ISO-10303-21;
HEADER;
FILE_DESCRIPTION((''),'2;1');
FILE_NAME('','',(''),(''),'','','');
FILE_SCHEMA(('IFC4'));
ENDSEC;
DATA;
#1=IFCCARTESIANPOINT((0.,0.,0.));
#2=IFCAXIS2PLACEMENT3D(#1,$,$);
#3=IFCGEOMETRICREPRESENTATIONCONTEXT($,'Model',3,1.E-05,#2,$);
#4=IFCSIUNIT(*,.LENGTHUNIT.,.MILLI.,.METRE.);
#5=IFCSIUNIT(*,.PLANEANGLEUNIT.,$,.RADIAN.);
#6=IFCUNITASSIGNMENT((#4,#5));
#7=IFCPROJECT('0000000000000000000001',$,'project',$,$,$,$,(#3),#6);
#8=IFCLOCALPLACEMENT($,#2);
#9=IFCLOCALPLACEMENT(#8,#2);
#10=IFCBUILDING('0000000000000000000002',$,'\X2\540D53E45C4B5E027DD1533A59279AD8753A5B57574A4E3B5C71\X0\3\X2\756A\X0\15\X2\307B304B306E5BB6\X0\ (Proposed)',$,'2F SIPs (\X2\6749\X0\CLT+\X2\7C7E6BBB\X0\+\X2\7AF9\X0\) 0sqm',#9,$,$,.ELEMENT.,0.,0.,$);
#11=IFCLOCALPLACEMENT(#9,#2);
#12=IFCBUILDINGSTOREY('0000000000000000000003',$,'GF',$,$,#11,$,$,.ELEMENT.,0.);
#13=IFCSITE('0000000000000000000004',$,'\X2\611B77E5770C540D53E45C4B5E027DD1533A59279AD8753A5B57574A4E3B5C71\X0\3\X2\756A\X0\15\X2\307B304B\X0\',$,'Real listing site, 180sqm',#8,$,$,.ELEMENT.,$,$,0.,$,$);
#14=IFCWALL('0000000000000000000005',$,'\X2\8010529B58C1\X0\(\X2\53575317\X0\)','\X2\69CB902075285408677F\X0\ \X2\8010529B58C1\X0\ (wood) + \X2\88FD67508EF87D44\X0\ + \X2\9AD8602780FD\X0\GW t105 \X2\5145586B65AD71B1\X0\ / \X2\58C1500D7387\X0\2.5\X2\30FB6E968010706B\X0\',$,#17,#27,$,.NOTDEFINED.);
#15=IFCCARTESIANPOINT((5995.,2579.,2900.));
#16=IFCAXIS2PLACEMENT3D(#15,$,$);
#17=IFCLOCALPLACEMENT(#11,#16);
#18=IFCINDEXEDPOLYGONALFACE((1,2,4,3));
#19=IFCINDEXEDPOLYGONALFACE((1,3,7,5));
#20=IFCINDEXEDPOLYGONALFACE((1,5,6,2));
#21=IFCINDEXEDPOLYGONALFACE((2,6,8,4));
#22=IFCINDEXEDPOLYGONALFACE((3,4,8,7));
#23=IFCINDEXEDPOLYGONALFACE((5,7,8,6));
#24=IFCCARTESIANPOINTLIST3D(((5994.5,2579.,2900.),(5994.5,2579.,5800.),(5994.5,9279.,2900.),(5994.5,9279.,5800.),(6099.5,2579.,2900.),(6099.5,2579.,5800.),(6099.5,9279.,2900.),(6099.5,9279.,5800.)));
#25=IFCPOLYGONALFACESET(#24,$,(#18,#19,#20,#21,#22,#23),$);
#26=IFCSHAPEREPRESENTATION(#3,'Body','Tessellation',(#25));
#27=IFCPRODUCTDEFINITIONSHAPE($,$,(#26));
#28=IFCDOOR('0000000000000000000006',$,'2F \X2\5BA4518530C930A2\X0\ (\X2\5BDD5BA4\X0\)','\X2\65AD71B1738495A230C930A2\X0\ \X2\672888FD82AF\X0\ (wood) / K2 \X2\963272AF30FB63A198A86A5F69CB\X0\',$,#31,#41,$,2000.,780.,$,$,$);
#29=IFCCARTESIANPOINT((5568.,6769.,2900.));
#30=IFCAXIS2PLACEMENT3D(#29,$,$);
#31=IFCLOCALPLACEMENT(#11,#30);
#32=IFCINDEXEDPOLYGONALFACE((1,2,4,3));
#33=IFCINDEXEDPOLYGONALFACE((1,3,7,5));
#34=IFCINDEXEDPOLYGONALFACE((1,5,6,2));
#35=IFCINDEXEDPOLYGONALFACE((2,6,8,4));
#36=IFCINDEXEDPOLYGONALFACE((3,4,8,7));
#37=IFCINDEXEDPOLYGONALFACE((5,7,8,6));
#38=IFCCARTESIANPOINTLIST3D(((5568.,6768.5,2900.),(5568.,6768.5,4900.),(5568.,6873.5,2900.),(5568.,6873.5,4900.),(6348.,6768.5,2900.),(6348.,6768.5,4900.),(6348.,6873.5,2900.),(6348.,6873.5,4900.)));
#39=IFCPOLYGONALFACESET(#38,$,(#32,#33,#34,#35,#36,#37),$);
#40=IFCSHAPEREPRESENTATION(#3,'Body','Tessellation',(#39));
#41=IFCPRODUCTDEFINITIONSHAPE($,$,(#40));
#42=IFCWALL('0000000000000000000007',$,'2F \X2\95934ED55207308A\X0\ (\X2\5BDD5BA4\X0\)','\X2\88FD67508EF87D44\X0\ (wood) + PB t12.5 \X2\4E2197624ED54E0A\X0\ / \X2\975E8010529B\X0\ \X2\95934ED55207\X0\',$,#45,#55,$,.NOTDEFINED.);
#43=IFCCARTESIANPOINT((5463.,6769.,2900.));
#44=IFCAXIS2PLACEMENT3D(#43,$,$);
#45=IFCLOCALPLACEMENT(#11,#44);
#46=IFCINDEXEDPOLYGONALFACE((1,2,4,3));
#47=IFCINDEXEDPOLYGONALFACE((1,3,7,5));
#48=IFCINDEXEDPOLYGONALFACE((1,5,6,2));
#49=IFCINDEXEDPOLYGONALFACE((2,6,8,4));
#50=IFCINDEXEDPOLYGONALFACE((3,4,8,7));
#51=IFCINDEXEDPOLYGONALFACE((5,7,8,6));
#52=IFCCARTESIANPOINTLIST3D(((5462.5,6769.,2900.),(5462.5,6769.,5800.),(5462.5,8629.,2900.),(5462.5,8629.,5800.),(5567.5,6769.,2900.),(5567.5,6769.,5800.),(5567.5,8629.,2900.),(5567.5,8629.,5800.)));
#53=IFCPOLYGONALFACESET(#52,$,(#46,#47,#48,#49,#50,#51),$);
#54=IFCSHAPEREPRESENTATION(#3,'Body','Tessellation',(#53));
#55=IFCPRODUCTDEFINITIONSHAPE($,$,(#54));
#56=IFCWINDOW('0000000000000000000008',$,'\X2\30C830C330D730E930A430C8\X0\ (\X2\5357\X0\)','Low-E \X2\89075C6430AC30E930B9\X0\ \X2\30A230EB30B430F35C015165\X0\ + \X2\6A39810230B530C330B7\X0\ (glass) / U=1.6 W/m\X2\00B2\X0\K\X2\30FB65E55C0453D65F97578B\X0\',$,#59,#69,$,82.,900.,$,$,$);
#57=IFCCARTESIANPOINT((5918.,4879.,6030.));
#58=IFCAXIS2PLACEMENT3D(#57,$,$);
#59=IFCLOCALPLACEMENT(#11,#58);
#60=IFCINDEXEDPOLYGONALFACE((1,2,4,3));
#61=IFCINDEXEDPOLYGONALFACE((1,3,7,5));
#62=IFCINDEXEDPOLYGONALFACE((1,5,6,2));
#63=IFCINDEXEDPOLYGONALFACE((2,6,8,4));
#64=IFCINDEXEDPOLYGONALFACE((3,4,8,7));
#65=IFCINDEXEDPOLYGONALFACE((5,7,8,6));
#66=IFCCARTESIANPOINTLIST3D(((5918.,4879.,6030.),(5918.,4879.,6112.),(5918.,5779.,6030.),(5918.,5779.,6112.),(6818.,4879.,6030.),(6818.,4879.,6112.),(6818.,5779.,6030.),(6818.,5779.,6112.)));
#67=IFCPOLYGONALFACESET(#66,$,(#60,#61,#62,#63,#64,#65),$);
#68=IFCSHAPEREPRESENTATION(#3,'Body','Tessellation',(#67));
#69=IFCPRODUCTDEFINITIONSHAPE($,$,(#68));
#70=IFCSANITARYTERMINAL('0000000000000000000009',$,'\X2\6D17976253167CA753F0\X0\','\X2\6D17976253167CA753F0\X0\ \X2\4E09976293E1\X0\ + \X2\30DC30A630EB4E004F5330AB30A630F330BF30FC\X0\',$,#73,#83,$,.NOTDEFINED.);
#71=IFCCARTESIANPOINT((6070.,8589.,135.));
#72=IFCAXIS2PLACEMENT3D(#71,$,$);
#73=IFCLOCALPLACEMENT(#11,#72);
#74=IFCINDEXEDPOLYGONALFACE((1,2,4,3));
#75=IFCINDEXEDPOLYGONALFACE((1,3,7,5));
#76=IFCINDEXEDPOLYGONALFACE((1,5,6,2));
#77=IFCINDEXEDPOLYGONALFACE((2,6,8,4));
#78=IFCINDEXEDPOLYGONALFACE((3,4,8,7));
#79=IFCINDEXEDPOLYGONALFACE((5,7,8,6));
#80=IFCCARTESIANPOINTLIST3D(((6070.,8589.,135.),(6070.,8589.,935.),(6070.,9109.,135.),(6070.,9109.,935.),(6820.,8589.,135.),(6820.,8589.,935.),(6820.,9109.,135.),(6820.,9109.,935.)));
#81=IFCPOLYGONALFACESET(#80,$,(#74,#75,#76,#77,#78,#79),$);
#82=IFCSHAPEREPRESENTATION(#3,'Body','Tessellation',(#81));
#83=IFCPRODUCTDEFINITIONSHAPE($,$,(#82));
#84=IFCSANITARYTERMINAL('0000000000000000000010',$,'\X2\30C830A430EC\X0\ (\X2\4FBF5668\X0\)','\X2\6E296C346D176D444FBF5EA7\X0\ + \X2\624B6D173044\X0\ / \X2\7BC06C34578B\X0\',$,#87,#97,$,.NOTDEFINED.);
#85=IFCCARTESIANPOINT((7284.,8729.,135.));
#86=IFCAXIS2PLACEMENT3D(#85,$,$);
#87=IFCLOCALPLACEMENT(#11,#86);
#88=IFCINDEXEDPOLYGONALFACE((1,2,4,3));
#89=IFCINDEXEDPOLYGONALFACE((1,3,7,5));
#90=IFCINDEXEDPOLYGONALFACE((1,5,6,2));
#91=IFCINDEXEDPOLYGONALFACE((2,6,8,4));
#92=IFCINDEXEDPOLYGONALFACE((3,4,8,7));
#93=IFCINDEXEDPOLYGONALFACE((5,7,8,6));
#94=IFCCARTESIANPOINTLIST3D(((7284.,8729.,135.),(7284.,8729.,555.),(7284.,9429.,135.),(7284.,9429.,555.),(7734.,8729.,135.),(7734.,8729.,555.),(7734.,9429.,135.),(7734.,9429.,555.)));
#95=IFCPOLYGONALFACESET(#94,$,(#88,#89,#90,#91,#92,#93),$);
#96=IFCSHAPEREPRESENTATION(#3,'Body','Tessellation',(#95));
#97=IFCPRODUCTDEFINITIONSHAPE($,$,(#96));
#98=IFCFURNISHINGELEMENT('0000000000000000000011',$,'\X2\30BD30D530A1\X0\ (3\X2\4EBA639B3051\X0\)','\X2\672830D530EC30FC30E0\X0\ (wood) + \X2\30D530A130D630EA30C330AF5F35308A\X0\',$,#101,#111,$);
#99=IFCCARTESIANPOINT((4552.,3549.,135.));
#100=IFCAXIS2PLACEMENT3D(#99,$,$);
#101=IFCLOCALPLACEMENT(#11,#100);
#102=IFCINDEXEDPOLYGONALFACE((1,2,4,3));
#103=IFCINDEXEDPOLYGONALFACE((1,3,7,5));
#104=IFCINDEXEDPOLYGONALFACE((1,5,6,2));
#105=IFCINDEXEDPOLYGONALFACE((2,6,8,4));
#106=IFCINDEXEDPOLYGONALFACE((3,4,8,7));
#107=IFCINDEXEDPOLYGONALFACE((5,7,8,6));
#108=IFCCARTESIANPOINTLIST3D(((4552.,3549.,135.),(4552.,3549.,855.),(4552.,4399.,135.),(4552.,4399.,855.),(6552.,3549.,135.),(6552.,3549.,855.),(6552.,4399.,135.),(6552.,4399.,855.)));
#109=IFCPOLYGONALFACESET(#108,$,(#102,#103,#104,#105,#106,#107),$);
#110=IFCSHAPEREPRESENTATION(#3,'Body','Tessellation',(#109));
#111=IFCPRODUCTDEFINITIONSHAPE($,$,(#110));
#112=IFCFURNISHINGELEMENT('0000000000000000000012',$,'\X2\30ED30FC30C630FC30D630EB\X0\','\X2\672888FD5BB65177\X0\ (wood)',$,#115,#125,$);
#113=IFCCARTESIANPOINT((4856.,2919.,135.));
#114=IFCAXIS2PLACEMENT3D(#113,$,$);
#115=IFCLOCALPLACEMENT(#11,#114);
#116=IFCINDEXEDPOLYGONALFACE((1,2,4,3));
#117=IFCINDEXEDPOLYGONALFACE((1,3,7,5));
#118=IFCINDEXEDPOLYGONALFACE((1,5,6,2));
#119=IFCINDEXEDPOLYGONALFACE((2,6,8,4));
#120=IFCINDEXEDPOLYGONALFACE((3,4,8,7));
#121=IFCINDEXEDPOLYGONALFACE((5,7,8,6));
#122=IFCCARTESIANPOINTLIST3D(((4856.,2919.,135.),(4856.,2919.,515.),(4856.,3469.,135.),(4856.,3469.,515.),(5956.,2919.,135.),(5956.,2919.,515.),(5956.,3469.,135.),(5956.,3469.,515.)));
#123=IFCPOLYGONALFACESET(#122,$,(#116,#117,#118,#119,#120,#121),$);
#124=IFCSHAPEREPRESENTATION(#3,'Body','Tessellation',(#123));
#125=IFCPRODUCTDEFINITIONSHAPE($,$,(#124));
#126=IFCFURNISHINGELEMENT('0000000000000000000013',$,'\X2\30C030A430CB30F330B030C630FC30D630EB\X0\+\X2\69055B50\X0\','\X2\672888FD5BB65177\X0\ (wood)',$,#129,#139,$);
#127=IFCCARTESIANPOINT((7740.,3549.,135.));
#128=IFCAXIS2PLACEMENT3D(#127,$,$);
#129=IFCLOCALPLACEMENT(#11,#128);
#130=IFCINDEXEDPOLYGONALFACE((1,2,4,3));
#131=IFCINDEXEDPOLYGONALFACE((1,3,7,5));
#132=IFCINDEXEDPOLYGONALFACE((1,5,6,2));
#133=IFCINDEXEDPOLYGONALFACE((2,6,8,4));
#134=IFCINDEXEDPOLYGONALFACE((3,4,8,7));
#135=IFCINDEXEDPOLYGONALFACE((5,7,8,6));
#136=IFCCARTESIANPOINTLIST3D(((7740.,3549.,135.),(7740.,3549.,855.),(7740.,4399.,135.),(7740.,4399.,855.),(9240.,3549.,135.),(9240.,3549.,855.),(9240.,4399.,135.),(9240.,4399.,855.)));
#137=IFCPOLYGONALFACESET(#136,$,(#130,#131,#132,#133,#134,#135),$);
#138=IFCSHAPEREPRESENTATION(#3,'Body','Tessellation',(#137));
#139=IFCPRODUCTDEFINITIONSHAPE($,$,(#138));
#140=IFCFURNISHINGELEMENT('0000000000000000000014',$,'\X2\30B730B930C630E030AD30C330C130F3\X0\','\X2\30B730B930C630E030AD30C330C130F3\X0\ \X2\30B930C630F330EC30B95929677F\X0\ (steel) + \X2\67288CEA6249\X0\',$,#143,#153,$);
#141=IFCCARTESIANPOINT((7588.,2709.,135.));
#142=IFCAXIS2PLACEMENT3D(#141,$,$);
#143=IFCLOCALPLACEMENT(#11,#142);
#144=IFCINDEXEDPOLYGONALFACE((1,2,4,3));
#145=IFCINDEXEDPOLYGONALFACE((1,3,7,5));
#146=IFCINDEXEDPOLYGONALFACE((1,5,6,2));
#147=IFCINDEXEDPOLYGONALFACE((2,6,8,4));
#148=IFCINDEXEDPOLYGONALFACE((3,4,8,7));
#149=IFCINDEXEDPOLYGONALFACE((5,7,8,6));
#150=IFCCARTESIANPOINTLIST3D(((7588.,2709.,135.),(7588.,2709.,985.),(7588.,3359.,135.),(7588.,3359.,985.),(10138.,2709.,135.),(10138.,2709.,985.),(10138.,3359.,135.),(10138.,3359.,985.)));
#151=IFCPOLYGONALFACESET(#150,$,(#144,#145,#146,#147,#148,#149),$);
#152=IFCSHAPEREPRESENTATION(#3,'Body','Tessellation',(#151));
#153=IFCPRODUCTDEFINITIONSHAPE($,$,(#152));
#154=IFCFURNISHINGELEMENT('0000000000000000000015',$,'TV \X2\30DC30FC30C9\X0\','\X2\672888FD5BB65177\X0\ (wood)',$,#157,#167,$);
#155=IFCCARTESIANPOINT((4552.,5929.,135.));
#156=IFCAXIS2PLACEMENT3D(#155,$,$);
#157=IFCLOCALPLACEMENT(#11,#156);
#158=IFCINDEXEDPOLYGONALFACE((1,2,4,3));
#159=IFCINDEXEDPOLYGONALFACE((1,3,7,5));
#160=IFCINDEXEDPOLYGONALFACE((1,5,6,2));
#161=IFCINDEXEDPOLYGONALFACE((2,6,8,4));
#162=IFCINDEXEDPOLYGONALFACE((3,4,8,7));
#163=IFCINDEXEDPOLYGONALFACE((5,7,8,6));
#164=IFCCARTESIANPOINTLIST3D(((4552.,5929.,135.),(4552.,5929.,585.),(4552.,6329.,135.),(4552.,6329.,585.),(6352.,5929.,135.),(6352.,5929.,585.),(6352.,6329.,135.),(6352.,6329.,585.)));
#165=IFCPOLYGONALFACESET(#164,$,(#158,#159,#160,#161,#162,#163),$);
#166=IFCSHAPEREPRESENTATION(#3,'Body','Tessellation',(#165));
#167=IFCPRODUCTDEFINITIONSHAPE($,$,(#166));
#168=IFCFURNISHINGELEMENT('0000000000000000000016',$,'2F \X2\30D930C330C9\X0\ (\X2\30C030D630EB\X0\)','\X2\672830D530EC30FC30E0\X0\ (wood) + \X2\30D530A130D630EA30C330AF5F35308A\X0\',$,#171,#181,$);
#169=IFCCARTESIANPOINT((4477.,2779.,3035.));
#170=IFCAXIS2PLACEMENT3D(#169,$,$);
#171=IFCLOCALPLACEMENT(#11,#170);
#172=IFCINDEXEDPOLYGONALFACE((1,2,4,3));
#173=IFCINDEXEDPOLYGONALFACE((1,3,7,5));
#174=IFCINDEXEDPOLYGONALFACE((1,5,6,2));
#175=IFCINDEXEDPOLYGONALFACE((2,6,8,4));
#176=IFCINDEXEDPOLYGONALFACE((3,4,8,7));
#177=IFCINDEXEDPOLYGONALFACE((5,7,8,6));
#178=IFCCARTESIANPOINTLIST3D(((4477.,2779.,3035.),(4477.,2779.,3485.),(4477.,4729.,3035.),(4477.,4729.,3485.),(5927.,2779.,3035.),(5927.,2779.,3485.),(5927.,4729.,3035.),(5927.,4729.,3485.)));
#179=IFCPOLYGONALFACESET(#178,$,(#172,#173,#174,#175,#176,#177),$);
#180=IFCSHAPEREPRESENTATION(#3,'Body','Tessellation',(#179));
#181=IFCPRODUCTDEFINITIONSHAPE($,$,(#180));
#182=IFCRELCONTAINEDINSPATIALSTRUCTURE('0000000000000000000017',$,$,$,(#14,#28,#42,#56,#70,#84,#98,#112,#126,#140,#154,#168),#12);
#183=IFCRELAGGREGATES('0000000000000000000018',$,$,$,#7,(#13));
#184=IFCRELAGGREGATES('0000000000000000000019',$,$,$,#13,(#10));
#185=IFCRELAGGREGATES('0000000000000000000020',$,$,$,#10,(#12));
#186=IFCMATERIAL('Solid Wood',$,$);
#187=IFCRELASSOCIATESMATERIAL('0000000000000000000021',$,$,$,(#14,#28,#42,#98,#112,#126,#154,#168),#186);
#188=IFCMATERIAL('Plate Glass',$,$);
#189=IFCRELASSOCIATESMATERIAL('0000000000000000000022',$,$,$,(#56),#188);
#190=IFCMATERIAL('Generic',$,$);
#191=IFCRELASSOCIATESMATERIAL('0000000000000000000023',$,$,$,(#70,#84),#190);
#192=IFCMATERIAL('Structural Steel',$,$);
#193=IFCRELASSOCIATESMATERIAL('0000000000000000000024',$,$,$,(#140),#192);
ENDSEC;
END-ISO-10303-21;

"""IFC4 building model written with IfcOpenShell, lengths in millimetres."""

from ifc_helpers import new_model, si_unit, frame, frame_2d, origin, place, context, project, spatial, rectangle, extrude, material, element, fill, save


model = new_model("IFC4")

# Units and contexts
model_context = context("Model", 3, precision=1e-05, world=origin())
ifc_project = project(units=[si_unit("LENGTHUNIT", "METRE", prefix="MILLI"), si_unit("PLANEANGLEUNIT", "RADIAN")], contexts=[model_context])

# Site, building, storey
site_placement = place(None, origin())
site = spatial("IfcSite", under=ifc_project, at=site_placement, Name="愛知県名古屋市緑区大高町字坊主山3番15ほか", ObjectType="Real listing site, 180sqm", CompositionType="ELEMENT", RefElevation=0.0)
building_placement = place(site_placement, origin())
building = spatial("IfcBuilding", under=site, at=building_placement, Name="名古屋市緑区大高町字坊主山3番15ほかの家 (Proposed)", ObjectType="2F SIPs (杉CLT+籾殻+竹) 0sqm", CompositionType="ELEMENT", ElevationOfRefHeight=0.0, ElevationOfTerrain=0.0)
storey_placement = place(building_placement, origin())
storey = spatial("IfcBuildingStorey", under=building, at=storey_placement, Name="GF", CompositionType="ELEMENT", Elevation=0.0)

# Shared definitions
ifc_material_1 = material(Name="Solid Wood")

# Wall, opening, door
wall_1_placement = place(storey_placement, frame((5995.0, 2579.0, 2900.0)))
wall_1 = element("IfcWall", 1, at=wall_1_placement, inside=storey, material=ifc_material_1, Name="耐力壁(南北)", Description="構造用合板 耐力壁 (wood) + 製材軸組 + 高性能GW t105 充填断熱 / 壁倍率2.5・準耐火", PredefinedType="NOTDEFINED", context=model_context, shape_type="SweptSolid", body=[
    extrude(rectangle(XDim=105.0, YDim=6700.0, at=frame_2d((52.0, 3350.0))), frame((5995.0, 2579.0, 2900.0)), (0.0, 0.0, 1.0), 2900.0),
])
opening_1_placement = place(storey_placement, frame((5568.0, 6769.0, 2900.0)))
opening_1 = element("IfcOpeningElement", 2, at=opening_1_placement, cuts=wall_1, PredefinedType="NOTDEFINED", context=model_context, shape_type="SweptSolid", body=[
    extrude(rectangle(XDim=780.0, YDim=105.0, at=frame_2d((390.0, 52.0))), frame((5568.0, 6769.0, 2900.0)), (0.0, 0.0, 1.0), 2000.0),
])
door_1_placement = place(storey_placement, frame((5568.0, 6769.0, 2900.0)))
door_1 = element("IfcDoor", 3, at=door_1_placement, inside=storey, material=ifc_material_1, Name="2F 室内ドア (寝室)", Description="断熱玄関ドア 木製芯 (wood) / K2 防犯・採風機構", OverallHeight=2000.0, OverallWidth=780.0, context=model_context, shape_type="SweptSolid", body=[
    extrude(rectangle(XDim=780.0, YDim=105.0, at=frame_2d((390.0, 52.0))), frame((5568.0, 6769.0, 2900.0)), (0.0, 0.0, 1.0), 2000.0),
])
fill(opening_1, door_1)

# Wall
wall_2_placement = place(storey_placement, frame((5463.0, 6769.0, 2900.0)))
element("IfcWall", 4, at=wall_2_placement, inside=storey, material=ifc_material_1, Name="2F 間仕切り (寝室)", Description="製材軸組 (wood) + PB t12.5 両面仕上 / 非耐力 間仕切", PredefinedType="NOTDEFINED", context=model_context, shape_type="SweptSolid", body=[
    extrude(rectangle(XDim=105.0, YDim=1860.0, at=frame_2d((52.0, 930.0))), frame((5463.0, 6769.0, 2900.0)), (0.0, 0.0, 1.0), 2900.0),
])

# Window
ifc_material_2 = material(Name="Plate Glass")
window_placement = place(storey_placement, frame((5918.0, 4879.0, 6030.0)))
element("IfcWindow", 5, at=window_placement, inside=storey, material=ifc_material_2, Name="トップライト (南)", Description="Low-E 複層ガラス アルゴン封入 + 樹脂サッシ (glass) / U=1.6 W/m²K・日射取得型", OverallHeight=82.0, OverallWidth=900.0, context=model_context, shape_type="SweptSolid", body=[
    extrude(rectangle(XDim=900.0, YDim=900.0, at=frame_2d((450.0, 450.0))), frame((5918.0, 4879.0, 6030.0)), (0.0, 0.0, 1.0), 82.0),
])

# Sanitary terminals
ifc_material_3 = material(Name="Generic")
sanitary_terminal_1_placement = place(storey_placement, frame((6070.0, 8589.0, 135.0)))
element("IfcSanitaryTerminal", 6, at=sanitary_terminal_1_placement, inside=storey, material=ifc_material_3, Name="洗面化粧台", Description="洗面化粧台 三面鏡 + ボウル一体カウンター", PredefinedType="NOTDEFINED", context=model_context, shape_type="SweptSolid", body=[
    extrude(rectangle(XDim=750.0, YDim=520.0, at=frame_2d((375.0, 260.0))), frame((6070.0, 8589.0, 135.0)), (0.0, 0.0, 1.0), 800.0),
])
sanitary_terminal_2_placement = place(storey_placement, frame((7284.0, 8729.0, 135.0)))
element("IfcSanitaryTerminal", 7, at=sanitary_terminal_2_placement, inside=storey, material=ifc_material_3, Name="トイレ (便器)", Description="温水洗浄便座 + 手洗い / 節水型", PredefinedType="NOTDEFINED", context=model_context, shape_type="SweptSolid", body=[
    extrude(rectangle(XDim=450.0, YDim=700.0, at=frame_2d((225.0, 350.0))), frame((7284.0, 8729.0, 135.0)), (0.0, 0.0, 1.0), 420.0),
])

# Furnishing elements
furnishing_1_placement = place(storey_placement, frame((4552.0, 3549.0, 135.0)))
element("IfcFurnishingElement", 8, at=furnishing_1_placement, inside=storey, material=ifc_material_1, Name="ソファ (3人掛け)", Description="木フレーム (wood) + ファブリック張り", context=model_context, shape_type="SweptSolid", body=[
    extrude(rectangle(XDim=2000.0, YDim=850.0, at=frame_2d((1000.0, 425.0))), frame((4552.0, 3549.0, 135.0)), (0.0, 0.0, 1.0), 720.0),
])
furnishing_2_placement = place(storey_placement, frame((4856.0, 2919.0, 135.0)))
element("IfcFurnishingElement", 9, at=furnishing_2_placement, inside=storey, material=ifc_material_1, Name="ローテーブル", Description="木製家具 (wood)", context=model_context, shape_type="SweptSolid", body=[
    extrude(rectangle(XDim=1100.0, YDim=550.0, at=frame_2d((550.0, 275.0))), frame((4856.0, 2919.0, 135.0)), (0.0, 0.0, 1.0), 380.0),
])
furnishing_3_placement = place(storey_placement, frame((7740.0, 3549.0, 135.0)))
element("IfcFurnishingElement", 10, at=furnishing_3_placement, inside=storey, material=ifc_material_1, Name="ダイニングテーブル+椅子", Description="木製家具 (wood)", context=model_context, shape_type="SweptSolid", body=[
    extrude(rectangle(XDim=1500.0, YDim=850.0, at=frame_2d((750.0, 425.0))), frame((7740.0, 3549.0, 135.0)), (0.0, 0.0, 1.0), 720.0),
])
ifc_material_4 = material(Name="Structural Steel")
furnishing_4_placement = place(storey_placement, frame((7588.0, 2709.0, 135.0)))
element("IfcFurnishingElement", 11, at=furnishing_4_placement, inside=storey, material=ifc_material_4, Name="システムキッチン", Description="システムキッチン ステンレス天板 (steel) + 木質扉", context=model_context, shape_type="SweptSolid", body=[
    extrude(rectangle(XDim=2550.0, YDim=650.0, at=frame_2d((1275.0, 325.0))), frame((7588.0, 2709.0, 135.0)), (0.0, 0.0, 1.0), 850.0),
])
furnishing_5_placement = place(storey_placement, frame((4552.0, 5929.0, 135.0)))
element("IfcFurnishingElement", 12, at=furnishing_5_placement, inside=storey, material=ifc_material_1, Name="TV ボード", Description="木製家具 (wood)", context=model_context, shape_type="SweptSolid", body=[
    extrude(rectangle(XDim=1800.0, YDim=400.0, at=frame_2d((900.0, 200.0))), frame((4552.0, 5929.0, 135.0)), (0.0, 0.0, 1.0), 450.0),
])
furnishing_6_placement = place(storey_placement, frame((4477.0, 2779.0, 3035.0)))
element("IfcFurnishingElement", 13, at=furnishing_6_placement, inside=storey, material=ifc_material_1, Name="2F ベッド (ダブル)", Description="木フレーム (wood) + ファブリック張り", context=model_context, shape_type="SweptSolid", body=[
    extrude(rectangle(XDim=1450.0, YDim=1950.0, at=frame_2d((725.0, 975.0))), frame((4477.0, 2779.0, 3035.0)), (0.0, 0.0, 1.0), 450.0),
])

save(model, "model.ifc")
